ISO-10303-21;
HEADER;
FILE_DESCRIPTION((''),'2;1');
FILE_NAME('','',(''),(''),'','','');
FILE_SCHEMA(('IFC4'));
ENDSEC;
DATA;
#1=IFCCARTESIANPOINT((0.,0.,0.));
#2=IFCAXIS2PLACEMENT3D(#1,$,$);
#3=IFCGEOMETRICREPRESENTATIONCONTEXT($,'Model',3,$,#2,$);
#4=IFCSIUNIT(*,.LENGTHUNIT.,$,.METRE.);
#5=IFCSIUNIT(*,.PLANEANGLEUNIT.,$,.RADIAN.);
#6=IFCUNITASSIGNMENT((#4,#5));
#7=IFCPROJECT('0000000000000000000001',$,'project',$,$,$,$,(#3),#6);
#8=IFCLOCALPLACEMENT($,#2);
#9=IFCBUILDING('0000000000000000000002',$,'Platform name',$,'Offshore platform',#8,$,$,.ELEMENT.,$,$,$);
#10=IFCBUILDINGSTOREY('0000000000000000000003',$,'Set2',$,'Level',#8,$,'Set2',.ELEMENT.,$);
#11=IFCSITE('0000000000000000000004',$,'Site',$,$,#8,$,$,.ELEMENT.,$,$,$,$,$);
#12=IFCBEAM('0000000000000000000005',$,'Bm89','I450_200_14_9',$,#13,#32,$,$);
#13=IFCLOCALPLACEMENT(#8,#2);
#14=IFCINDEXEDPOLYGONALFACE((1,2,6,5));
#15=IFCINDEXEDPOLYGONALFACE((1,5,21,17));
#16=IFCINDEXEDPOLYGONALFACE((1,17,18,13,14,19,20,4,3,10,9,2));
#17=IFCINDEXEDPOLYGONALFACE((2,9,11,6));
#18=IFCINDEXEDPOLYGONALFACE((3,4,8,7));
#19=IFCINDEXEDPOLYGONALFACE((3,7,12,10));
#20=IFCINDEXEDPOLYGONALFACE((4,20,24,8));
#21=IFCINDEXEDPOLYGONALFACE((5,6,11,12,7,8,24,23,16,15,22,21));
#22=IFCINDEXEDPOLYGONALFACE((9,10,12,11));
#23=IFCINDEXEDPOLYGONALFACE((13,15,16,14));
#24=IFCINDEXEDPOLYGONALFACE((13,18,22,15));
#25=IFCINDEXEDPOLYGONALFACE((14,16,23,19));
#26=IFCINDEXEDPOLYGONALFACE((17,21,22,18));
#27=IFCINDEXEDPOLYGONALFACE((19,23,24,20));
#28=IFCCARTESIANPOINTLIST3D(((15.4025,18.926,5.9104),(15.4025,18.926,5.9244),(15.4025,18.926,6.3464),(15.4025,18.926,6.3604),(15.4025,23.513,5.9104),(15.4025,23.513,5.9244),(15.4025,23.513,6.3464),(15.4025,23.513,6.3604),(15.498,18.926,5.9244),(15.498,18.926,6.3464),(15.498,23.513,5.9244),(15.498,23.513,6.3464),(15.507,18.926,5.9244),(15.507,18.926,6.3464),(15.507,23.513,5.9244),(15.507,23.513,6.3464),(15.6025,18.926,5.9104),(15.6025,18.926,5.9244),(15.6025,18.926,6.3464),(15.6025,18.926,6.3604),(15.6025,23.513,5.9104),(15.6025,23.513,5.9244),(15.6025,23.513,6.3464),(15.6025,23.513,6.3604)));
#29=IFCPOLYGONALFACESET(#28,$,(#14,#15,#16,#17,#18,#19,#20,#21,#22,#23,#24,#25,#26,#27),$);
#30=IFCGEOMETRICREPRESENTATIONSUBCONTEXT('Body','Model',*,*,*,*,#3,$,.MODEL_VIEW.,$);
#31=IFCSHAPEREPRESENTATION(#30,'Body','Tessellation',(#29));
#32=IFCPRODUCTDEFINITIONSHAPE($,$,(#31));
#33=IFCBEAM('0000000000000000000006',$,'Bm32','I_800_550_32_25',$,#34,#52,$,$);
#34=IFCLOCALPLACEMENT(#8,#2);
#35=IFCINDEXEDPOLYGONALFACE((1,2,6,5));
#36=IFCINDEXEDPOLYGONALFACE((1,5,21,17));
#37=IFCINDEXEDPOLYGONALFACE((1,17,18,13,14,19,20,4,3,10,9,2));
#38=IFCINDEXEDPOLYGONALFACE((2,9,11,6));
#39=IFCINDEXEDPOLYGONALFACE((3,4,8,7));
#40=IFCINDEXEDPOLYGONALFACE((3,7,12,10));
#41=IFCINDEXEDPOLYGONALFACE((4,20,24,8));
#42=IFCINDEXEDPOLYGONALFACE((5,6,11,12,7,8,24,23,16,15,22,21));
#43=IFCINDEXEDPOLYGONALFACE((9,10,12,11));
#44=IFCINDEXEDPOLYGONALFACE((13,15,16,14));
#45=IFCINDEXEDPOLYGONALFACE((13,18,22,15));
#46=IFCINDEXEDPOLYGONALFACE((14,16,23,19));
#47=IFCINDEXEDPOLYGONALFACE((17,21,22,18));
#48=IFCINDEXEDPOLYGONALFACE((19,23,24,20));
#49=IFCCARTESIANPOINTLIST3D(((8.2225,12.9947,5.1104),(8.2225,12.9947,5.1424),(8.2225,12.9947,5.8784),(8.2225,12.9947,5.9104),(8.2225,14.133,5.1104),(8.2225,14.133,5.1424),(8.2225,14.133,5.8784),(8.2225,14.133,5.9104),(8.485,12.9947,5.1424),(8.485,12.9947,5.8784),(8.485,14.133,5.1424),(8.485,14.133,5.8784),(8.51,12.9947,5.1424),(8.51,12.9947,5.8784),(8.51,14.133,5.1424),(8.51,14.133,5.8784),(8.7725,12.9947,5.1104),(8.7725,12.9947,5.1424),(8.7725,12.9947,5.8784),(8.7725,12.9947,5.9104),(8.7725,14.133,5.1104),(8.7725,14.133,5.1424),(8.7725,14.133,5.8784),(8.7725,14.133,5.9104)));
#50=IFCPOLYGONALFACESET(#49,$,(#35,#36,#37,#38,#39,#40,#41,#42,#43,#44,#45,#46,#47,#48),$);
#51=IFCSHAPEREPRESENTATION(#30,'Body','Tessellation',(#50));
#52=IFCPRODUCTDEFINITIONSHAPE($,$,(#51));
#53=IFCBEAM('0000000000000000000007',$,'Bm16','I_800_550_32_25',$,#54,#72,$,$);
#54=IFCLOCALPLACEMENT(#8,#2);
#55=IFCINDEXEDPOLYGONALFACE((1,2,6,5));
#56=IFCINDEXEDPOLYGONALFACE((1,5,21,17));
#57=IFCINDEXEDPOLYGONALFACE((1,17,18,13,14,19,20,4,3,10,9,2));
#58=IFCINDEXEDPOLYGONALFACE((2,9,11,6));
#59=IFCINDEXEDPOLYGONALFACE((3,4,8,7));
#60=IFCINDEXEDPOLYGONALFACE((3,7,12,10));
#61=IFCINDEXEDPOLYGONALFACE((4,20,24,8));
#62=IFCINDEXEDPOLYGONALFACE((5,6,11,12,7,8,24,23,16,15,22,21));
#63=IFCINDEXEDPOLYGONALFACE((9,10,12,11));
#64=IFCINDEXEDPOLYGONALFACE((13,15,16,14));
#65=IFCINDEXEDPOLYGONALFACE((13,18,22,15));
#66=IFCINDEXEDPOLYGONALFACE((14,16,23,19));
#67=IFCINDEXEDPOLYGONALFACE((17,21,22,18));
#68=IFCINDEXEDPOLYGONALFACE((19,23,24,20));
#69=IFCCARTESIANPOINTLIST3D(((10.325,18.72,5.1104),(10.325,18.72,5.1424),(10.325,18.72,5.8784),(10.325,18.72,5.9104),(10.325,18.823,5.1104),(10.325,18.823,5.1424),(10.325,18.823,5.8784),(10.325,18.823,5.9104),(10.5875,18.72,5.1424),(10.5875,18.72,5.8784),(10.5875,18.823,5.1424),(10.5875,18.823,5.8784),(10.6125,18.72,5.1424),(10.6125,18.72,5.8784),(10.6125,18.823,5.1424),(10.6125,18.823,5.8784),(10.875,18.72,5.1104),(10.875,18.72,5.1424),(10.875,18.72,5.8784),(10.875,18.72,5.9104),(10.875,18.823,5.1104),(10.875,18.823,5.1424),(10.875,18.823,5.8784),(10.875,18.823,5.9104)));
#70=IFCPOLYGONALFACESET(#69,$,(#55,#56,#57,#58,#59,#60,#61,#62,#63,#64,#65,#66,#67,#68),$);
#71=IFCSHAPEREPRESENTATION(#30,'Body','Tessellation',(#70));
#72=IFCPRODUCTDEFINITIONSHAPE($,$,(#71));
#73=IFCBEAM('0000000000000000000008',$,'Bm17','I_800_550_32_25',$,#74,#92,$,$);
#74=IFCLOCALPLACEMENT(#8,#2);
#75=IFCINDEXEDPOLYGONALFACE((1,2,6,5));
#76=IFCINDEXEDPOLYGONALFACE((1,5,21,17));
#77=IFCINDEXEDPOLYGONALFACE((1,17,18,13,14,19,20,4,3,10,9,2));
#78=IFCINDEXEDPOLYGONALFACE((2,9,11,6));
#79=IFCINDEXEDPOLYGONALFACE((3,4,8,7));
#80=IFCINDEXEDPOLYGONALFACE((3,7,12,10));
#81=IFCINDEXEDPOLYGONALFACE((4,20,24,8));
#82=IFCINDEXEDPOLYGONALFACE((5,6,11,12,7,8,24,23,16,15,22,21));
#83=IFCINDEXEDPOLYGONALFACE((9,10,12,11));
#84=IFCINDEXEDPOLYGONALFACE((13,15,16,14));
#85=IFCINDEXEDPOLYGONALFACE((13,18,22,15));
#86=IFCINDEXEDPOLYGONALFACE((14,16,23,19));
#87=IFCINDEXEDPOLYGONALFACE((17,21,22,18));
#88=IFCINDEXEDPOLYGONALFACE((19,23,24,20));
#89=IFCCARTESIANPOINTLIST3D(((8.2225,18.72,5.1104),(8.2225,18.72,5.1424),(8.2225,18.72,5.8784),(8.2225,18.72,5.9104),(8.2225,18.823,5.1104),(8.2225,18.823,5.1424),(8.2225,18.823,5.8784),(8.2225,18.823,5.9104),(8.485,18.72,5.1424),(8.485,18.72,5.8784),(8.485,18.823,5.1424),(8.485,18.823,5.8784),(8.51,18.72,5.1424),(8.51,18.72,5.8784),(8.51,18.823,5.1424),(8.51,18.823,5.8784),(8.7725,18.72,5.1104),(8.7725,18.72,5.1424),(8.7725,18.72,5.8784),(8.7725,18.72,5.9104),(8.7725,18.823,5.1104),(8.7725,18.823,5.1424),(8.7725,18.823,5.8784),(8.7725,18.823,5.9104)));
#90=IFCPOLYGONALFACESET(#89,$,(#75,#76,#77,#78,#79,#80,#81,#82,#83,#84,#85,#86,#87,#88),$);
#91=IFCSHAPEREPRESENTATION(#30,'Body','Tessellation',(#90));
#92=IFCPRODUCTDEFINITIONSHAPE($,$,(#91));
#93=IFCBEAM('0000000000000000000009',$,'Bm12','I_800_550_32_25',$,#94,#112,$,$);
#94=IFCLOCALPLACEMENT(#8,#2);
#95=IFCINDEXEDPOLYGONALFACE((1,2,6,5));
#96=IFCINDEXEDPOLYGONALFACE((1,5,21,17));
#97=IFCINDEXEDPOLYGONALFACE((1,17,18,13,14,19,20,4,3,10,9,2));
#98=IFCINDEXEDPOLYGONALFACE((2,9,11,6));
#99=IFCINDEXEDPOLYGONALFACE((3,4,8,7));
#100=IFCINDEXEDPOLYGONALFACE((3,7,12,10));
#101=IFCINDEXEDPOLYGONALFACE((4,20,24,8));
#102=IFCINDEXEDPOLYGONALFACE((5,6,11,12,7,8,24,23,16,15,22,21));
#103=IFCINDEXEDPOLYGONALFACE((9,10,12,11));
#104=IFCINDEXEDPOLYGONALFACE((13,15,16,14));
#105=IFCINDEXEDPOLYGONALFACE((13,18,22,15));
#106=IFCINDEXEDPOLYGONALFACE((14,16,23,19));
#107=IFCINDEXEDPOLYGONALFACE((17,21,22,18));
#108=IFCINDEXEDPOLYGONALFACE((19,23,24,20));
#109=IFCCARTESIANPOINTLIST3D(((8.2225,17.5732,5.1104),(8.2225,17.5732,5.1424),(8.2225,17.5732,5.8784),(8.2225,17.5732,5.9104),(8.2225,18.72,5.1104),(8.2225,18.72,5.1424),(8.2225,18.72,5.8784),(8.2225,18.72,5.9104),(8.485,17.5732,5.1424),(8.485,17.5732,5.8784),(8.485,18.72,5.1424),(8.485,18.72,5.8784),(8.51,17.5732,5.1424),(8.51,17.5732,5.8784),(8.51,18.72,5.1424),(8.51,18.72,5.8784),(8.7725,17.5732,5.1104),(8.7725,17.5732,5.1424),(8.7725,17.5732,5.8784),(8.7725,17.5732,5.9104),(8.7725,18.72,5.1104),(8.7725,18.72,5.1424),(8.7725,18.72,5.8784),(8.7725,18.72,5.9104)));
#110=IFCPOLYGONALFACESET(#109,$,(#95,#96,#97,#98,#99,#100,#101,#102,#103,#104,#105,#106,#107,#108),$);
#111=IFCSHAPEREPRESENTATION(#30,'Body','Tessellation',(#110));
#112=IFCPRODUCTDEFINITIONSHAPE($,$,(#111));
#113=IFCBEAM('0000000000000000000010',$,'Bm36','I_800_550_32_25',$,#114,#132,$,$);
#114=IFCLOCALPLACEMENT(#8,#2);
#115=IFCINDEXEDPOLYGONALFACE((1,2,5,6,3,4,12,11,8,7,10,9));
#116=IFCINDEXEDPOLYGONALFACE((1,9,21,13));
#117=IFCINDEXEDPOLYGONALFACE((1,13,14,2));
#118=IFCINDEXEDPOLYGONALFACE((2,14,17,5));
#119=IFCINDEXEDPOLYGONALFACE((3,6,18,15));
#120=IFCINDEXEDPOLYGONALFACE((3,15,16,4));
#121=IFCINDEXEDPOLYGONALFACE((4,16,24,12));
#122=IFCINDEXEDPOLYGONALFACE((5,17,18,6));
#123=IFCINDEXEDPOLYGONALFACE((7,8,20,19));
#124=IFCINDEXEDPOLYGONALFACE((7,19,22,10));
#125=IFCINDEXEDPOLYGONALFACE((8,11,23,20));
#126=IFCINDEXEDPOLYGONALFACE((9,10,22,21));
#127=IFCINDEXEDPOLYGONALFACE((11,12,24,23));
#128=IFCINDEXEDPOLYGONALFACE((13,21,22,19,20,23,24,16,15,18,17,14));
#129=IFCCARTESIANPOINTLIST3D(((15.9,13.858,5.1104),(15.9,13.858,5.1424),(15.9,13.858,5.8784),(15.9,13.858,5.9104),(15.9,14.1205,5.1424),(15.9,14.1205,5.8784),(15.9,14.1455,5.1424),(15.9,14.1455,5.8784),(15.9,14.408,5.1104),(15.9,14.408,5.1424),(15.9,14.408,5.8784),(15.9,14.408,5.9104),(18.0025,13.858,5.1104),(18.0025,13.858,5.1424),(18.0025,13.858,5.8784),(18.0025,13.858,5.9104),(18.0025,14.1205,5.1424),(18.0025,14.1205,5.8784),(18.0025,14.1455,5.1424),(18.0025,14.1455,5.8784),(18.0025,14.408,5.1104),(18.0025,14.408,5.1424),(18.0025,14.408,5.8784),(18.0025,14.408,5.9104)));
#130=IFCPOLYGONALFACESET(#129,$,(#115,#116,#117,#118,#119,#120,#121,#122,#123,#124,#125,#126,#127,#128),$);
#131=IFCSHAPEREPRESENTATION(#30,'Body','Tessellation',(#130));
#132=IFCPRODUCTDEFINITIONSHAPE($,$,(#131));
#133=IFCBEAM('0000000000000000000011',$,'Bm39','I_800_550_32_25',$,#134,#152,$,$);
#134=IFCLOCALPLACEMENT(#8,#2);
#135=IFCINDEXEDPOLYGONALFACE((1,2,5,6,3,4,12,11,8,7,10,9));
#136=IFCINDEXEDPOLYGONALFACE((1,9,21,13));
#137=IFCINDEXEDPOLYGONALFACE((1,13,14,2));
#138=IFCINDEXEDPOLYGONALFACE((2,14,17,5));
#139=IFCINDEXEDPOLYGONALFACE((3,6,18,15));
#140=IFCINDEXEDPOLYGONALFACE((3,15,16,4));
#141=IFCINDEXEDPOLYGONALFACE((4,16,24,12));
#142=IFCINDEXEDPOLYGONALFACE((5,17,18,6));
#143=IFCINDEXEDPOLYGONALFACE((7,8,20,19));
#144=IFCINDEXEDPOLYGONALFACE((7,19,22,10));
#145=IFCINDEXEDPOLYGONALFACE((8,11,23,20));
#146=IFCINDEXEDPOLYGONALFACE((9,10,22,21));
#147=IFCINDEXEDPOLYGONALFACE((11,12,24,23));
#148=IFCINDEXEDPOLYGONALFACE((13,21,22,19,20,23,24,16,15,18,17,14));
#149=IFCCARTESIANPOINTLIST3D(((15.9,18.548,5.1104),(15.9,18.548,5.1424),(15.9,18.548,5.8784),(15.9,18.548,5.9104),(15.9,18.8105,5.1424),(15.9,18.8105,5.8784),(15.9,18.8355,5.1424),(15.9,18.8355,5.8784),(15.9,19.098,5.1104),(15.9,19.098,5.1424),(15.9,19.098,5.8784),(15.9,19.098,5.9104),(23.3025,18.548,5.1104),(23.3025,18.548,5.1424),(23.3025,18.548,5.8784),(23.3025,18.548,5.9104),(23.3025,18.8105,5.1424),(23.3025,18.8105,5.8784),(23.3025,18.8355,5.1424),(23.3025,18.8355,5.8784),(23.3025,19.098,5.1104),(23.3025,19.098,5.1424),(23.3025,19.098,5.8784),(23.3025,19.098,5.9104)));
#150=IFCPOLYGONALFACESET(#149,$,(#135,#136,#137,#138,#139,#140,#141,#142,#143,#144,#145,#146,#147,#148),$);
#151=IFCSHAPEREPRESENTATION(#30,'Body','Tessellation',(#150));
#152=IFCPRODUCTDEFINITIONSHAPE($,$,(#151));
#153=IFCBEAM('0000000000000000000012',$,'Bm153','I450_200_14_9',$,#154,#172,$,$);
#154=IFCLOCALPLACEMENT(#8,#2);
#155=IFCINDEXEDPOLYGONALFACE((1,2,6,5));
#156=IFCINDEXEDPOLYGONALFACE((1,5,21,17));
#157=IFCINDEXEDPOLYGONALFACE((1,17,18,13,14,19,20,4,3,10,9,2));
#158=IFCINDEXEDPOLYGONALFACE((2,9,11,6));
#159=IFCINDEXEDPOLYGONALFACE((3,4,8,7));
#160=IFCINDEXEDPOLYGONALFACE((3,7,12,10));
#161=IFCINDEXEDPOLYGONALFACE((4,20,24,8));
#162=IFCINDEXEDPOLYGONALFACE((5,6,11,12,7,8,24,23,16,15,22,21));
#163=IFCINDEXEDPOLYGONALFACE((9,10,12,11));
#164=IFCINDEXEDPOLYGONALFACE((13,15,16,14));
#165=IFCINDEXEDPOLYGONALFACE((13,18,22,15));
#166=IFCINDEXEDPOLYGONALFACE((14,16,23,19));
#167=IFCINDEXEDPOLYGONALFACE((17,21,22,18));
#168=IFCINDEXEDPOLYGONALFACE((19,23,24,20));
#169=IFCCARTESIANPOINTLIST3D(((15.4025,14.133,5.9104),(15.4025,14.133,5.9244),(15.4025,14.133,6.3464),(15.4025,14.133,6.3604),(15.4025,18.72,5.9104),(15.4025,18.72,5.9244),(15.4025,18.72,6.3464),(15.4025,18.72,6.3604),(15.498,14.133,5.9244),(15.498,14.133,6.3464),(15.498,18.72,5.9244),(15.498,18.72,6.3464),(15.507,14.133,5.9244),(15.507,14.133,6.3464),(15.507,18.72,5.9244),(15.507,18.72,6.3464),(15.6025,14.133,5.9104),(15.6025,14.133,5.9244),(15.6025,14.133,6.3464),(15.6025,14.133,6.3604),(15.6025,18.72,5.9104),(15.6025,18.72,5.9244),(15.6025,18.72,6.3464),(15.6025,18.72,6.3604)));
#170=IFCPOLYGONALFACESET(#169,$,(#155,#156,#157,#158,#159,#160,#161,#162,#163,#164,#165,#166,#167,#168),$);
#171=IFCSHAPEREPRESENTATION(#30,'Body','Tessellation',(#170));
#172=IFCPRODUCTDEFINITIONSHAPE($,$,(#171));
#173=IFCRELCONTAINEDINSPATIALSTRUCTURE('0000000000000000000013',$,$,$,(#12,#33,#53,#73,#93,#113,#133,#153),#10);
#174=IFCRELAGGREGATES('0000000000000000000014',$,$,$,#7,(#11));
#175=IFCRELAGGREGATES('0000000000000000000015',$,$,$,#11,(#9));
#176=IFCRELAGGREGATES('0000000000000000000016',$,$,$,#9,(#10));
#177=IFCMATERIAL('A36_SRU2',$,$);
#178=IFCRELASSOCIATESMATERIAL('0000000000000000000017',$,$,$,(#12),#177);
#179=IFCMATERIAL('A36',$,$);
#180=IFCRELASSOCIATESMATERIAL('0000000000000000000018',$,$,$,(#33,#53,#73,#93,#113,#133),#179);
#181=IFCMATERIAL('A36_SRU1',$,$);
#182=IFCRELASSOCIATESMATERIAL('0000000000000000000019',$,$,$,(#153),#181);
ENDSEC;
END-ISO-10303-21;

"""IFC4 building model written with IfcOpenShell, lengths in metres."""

from ifc_helpers import new_model, si_unit, frame, origin, origin_2d, place, context, subcontext, project, spatial, i_section, extrude, source, transform, mapped, material, element, save


model = new_model("IFC4")

# Units and contexts
model_context = context("Model", 3, world=origin())
body_context = subcontext(model_context, "Body", "Model", "MODEL_VIEW")
ifc_project = project(units=[si_unit("LENGTHUNIT", "METRE"), si_unit("PLANEANGLEUNIT", "RADIAN")], contexts=[model_context])

# Site, building, storey
placement_1 = place(None, origin())
site = spatial("IfcSite", under=ifc_project, at=placement_1, Name="Site", CompositionType="ELEMENT")
building = spatial("IfcBuilding", under=site, at=placement_1, Name="Platform name", ObjectType="Offshore platform", CompositionType="ELEMENT")
storey = spatial("IfcBuildingStorey", under=building, at=placement_1, Name="Set2", ObjectType="Level", LongName="Set2", CompositionType="ELEMENT")

# Beams
ifc_material_1 = material(Name="A36_SRU2")
shared_shape_1 = source(origin(), body_context, "Body", "SweptSolid", [
    extrude(i_section(OverallWidth=0.2, OverallDepth=0.45, WebThickness=0.009, FlangeThickness=0.014, FilletRadius=0.0, at=origin_2d()), frame((0.0, 0.0, 0.0), z_axis=(0.0, 1.0, 0.0), x_axis=(-1.0, 0.0, 0.0)), (0.0, 0.0, 1.0), 4.587),
])
placement_2 = place(None, origin())
placement_3 = place(placement_2, origin())
placement_4 = place(placement_3, origin())
beam_1_placement = place(placement_4, frame((15.5025, 18.926, 6.1354)))
element("IfcBeam", 1, at=beam_1_placement, inside=storey, material=ifc_material_1, Name="Bm89", Description="I450_200_14_9", context=body_context, shape_type="MappedRepresentation", body=[
    mapped(shared_shape_1, transform((0.0, 0.0, 0.0), scale=1.0)),
])
ifc_material_2 = material(Name="A36")
shared_shape_2 = source(origin(), body_context, "Body", "SweptSolid", [
    extrude(i_section(OverallWidth=0.55, OverallDepth=0.8, WebThickness=0.025, FlangeThickness=0.032, FilletRadius=0.0, at=origin_2d()), frame((0.0, 0.0, 0.0), z_axis=(0.0, -1.0, 0.0), x_axis=(1.0, 0.0, 0.0)), (0.0, 0.0, 1.0), 1.1383),
])
placement_5 = place(None, origin())
placement_6 = place(placement_5, origin())
placement_7 = place(placement_6, origin())
beam_2_placement = place(placement_7, frame((8.4975, 14.133, 5.5104)))
element("IfcBeam", 2, at=beam_2_placement, inside=storey, material=ifc_material_2, Name="Bm32", Description="I_800_550_32_25", context=body_context, shape_type="MappedRepresentation", body=[
    mapped(shared_shape_2, transform((0.0, 0.0, 0.0), scale=1.0)),
])
shared_shape_3 = source(origin(), body_context, "Body", "SweptSolid", [
    extrude(i_section(OverallWidth=0.55, OverallDepth=0.8, WebThickness=0.025, FlangeThickness=0.032, FilletRadius=0.0, at=origin_2d()), frame((0.0, 0.0, 0.0), z_axis=(0.0, -1.0, 0.0), x_axis=(1.0, 0.0, 0.0)), (0.0, 0.0, 1.0), 0.103),
])
placement_8 = place(None, origin())
placement_9 = place(placement_8, origin())
placement_10 = place(placement_9, origin())
beam_3_placement = place(placement_10, frame((10.6, 18.823, 5.5104)))
element("IfcBeam", 3, at=beam_3_placement, inside=storey, material=ifc_material_2, Name="Bm16", Description="I_800_550_32_25", context=body_context, shape_type="MappedRepresentation", body=[
    mapped(shared_shape_3, transform((0.0, 0.0, 0.0), scale=1.0)),
])
shared_shape_4 = source(origin(), body_context, "Body", "SweptSolid", [
    extrude(i_section(OverallWidth=0.55, OverallDepth=0.8, WebThickness=0.025, FlangeThickness=0.032, FilletRadius=0.0, at=origin_2d()), frame((0.0, 0.0, 0.0), z_axis=(0.0, -1.0, 0.0), x_axis=(1.0, 0.0, 0.0)), (0.0, 0.0, 1.0), 0.103),
])
placement_11 = place(None, origin())
placement_12 = place(placement_11, origin())
placement_13 = place(placement_12, origin())
beam_4_placement = place(placement_13, frame((8.4975, 18.823, 5.5104)))
element("IfcBeam", 4, at=beam_4_placement, inside=storey, material=ifc_material_2, Name="Bm17", Description="I_800_550_32_25", context=body_context, shape_type="MappedRepresentation", body=[
    mapped(shared_shape_4, transform((0.0, 0.0, 0.0), scale=1.0)),
])
shared_shape_5 = source(origin(), body_context, "Body", "SweptSolid", [
    extrude(i_section(OverallWidth=0.55, OverallDepth=0.8, WebThickness=0.025, FlangeThickness=0.032, FilletRadius=0.0, at=origin_2d()), frame((0.0, 0.0, 0.0), z_axis=(0.0, -1.0, 0.0), x_axis=(1.0, 0.0, 0.0)), (0.0, 0.0, 1.0), 1.1467),
])
placement_14 = place(None, origin())
placement_15 = place(placement_14, origin())
placement_16 = place(placement_15, origin())
beam_5_placement = place(placement_16, frame((8.4975, 18.72, 5.5104)))
element("IfcBeam", 5, at=beam_5_placement, inside=storey, material=ifc_material_2, Name="Bm12", Description="I_800_550_32_25", context=body_context, shape_type="MappedRepresentation", body=[
    mapped(shared_shape_5, transform((0.0, 0.0, 0.0), scale=1.0)),
])
shared_shape_6 = source(origin(), body_context, "Body", "SweptSolid", [
    extrude(i_section(OverallWidth=0.55, OverallDepth=0.8, WebThickness=0.025, FlangeThickness=0.032, FilletRadius=0.0, at=origin_2d()), frame((0.0, 0.0, 0.0), z_axis=(1.0, 0.0, 0.0), x_axis=(0.0, 1.0, 0.0)), (0.0, 0.0, 1.0), 2.1025),
])
placement_17 = place(None, origin())
placement_18 = place(placement_17, origin())
placement_19 = place(placement_18, origin())
beam_6_placement = place(placement_19, frame((15.9, 14.133, 5.5104)))
element("IfcBeam", 6, at=beam_6_placement, inside=storey, material=ifc_material_2, Name="Bm36", Description="I_800_550_32_25", context=body_context, shape_type="MappedRepresentation", body=[
    mapped(shared_shape_6, transform((0.0, 0.0, 0.0), scale=1.0)),
])
shared_shape_7 = source(origin(), body_context, "Body", "SweptSolid", [
    extrude(i_section(OverallWidth=0.55, OverallDepth=0.8, WebThickness=0.025, FlangeThickness=0.032, FilletRadius=0.0, at=origin_2d()), frame((0.0, 0.0, 0.0), z_axis=(1.0, 0.0, 0.0), x_axis=(0.0, 1.0, 0.0)), (0.0, 0.0, 1.0), 7.4025),
])
placement_20 = place(None, origin())
placement_21 = place(placement_20, origin())
placement_22 = place(placement_21, origin())
beam_7_placement = place(placement_22, frame((15.9, 18.823, 5.5104)))
element("IfcBeam", 7, at=beam_7_placement, inside=storey, material=ifc_material_2, Name="Bm39", Description="I_800_550_32_25", context=body_context, shape_type="MappedRepresentation", body=[
    mapped(shared_shape_7, transform((0.0, 0.0, 0.0), scale=1.0)),
])
ifc_material_3 = material(Name="A36_SRU1")
shared_shape_8 = source(origin(), body_context, "Body", "SweptSolid", [
    extrude(i_section(OverallWidth=0.2, OverallDepth=0.45, WebThickness=0.009, FlangeThickness=0.014, FilletRadius=0.0, at=origin_2d()), frame((0.0, 0.0, 0.0), z_axis=(0.0, 1.0, 0.0), x_axis=(-1.0, 0.0, 0.0)), (0.0, 0.0, 1.0), 4.587),
])
placement_23 = place(None, origin())
placement_24 = place(placement_23, origin())
placement_25 = place(placement_24, origin())
beam_8_placement = place(placement_25, frame((15.5025, 14.133, 6.1354)))
element("IfcBeam", 8, at=beam_8_placement, inside=storey, material=ifc_material_3, Name="Bm153", Description="I450_200_14_9", context=body_context, shape_type="MappedRepresentation", body=[
    mapped(shared_shape_8, transform((0.0, 0.0, 0.0), scale=1.0)),
])

save(model, "model.ifc")
